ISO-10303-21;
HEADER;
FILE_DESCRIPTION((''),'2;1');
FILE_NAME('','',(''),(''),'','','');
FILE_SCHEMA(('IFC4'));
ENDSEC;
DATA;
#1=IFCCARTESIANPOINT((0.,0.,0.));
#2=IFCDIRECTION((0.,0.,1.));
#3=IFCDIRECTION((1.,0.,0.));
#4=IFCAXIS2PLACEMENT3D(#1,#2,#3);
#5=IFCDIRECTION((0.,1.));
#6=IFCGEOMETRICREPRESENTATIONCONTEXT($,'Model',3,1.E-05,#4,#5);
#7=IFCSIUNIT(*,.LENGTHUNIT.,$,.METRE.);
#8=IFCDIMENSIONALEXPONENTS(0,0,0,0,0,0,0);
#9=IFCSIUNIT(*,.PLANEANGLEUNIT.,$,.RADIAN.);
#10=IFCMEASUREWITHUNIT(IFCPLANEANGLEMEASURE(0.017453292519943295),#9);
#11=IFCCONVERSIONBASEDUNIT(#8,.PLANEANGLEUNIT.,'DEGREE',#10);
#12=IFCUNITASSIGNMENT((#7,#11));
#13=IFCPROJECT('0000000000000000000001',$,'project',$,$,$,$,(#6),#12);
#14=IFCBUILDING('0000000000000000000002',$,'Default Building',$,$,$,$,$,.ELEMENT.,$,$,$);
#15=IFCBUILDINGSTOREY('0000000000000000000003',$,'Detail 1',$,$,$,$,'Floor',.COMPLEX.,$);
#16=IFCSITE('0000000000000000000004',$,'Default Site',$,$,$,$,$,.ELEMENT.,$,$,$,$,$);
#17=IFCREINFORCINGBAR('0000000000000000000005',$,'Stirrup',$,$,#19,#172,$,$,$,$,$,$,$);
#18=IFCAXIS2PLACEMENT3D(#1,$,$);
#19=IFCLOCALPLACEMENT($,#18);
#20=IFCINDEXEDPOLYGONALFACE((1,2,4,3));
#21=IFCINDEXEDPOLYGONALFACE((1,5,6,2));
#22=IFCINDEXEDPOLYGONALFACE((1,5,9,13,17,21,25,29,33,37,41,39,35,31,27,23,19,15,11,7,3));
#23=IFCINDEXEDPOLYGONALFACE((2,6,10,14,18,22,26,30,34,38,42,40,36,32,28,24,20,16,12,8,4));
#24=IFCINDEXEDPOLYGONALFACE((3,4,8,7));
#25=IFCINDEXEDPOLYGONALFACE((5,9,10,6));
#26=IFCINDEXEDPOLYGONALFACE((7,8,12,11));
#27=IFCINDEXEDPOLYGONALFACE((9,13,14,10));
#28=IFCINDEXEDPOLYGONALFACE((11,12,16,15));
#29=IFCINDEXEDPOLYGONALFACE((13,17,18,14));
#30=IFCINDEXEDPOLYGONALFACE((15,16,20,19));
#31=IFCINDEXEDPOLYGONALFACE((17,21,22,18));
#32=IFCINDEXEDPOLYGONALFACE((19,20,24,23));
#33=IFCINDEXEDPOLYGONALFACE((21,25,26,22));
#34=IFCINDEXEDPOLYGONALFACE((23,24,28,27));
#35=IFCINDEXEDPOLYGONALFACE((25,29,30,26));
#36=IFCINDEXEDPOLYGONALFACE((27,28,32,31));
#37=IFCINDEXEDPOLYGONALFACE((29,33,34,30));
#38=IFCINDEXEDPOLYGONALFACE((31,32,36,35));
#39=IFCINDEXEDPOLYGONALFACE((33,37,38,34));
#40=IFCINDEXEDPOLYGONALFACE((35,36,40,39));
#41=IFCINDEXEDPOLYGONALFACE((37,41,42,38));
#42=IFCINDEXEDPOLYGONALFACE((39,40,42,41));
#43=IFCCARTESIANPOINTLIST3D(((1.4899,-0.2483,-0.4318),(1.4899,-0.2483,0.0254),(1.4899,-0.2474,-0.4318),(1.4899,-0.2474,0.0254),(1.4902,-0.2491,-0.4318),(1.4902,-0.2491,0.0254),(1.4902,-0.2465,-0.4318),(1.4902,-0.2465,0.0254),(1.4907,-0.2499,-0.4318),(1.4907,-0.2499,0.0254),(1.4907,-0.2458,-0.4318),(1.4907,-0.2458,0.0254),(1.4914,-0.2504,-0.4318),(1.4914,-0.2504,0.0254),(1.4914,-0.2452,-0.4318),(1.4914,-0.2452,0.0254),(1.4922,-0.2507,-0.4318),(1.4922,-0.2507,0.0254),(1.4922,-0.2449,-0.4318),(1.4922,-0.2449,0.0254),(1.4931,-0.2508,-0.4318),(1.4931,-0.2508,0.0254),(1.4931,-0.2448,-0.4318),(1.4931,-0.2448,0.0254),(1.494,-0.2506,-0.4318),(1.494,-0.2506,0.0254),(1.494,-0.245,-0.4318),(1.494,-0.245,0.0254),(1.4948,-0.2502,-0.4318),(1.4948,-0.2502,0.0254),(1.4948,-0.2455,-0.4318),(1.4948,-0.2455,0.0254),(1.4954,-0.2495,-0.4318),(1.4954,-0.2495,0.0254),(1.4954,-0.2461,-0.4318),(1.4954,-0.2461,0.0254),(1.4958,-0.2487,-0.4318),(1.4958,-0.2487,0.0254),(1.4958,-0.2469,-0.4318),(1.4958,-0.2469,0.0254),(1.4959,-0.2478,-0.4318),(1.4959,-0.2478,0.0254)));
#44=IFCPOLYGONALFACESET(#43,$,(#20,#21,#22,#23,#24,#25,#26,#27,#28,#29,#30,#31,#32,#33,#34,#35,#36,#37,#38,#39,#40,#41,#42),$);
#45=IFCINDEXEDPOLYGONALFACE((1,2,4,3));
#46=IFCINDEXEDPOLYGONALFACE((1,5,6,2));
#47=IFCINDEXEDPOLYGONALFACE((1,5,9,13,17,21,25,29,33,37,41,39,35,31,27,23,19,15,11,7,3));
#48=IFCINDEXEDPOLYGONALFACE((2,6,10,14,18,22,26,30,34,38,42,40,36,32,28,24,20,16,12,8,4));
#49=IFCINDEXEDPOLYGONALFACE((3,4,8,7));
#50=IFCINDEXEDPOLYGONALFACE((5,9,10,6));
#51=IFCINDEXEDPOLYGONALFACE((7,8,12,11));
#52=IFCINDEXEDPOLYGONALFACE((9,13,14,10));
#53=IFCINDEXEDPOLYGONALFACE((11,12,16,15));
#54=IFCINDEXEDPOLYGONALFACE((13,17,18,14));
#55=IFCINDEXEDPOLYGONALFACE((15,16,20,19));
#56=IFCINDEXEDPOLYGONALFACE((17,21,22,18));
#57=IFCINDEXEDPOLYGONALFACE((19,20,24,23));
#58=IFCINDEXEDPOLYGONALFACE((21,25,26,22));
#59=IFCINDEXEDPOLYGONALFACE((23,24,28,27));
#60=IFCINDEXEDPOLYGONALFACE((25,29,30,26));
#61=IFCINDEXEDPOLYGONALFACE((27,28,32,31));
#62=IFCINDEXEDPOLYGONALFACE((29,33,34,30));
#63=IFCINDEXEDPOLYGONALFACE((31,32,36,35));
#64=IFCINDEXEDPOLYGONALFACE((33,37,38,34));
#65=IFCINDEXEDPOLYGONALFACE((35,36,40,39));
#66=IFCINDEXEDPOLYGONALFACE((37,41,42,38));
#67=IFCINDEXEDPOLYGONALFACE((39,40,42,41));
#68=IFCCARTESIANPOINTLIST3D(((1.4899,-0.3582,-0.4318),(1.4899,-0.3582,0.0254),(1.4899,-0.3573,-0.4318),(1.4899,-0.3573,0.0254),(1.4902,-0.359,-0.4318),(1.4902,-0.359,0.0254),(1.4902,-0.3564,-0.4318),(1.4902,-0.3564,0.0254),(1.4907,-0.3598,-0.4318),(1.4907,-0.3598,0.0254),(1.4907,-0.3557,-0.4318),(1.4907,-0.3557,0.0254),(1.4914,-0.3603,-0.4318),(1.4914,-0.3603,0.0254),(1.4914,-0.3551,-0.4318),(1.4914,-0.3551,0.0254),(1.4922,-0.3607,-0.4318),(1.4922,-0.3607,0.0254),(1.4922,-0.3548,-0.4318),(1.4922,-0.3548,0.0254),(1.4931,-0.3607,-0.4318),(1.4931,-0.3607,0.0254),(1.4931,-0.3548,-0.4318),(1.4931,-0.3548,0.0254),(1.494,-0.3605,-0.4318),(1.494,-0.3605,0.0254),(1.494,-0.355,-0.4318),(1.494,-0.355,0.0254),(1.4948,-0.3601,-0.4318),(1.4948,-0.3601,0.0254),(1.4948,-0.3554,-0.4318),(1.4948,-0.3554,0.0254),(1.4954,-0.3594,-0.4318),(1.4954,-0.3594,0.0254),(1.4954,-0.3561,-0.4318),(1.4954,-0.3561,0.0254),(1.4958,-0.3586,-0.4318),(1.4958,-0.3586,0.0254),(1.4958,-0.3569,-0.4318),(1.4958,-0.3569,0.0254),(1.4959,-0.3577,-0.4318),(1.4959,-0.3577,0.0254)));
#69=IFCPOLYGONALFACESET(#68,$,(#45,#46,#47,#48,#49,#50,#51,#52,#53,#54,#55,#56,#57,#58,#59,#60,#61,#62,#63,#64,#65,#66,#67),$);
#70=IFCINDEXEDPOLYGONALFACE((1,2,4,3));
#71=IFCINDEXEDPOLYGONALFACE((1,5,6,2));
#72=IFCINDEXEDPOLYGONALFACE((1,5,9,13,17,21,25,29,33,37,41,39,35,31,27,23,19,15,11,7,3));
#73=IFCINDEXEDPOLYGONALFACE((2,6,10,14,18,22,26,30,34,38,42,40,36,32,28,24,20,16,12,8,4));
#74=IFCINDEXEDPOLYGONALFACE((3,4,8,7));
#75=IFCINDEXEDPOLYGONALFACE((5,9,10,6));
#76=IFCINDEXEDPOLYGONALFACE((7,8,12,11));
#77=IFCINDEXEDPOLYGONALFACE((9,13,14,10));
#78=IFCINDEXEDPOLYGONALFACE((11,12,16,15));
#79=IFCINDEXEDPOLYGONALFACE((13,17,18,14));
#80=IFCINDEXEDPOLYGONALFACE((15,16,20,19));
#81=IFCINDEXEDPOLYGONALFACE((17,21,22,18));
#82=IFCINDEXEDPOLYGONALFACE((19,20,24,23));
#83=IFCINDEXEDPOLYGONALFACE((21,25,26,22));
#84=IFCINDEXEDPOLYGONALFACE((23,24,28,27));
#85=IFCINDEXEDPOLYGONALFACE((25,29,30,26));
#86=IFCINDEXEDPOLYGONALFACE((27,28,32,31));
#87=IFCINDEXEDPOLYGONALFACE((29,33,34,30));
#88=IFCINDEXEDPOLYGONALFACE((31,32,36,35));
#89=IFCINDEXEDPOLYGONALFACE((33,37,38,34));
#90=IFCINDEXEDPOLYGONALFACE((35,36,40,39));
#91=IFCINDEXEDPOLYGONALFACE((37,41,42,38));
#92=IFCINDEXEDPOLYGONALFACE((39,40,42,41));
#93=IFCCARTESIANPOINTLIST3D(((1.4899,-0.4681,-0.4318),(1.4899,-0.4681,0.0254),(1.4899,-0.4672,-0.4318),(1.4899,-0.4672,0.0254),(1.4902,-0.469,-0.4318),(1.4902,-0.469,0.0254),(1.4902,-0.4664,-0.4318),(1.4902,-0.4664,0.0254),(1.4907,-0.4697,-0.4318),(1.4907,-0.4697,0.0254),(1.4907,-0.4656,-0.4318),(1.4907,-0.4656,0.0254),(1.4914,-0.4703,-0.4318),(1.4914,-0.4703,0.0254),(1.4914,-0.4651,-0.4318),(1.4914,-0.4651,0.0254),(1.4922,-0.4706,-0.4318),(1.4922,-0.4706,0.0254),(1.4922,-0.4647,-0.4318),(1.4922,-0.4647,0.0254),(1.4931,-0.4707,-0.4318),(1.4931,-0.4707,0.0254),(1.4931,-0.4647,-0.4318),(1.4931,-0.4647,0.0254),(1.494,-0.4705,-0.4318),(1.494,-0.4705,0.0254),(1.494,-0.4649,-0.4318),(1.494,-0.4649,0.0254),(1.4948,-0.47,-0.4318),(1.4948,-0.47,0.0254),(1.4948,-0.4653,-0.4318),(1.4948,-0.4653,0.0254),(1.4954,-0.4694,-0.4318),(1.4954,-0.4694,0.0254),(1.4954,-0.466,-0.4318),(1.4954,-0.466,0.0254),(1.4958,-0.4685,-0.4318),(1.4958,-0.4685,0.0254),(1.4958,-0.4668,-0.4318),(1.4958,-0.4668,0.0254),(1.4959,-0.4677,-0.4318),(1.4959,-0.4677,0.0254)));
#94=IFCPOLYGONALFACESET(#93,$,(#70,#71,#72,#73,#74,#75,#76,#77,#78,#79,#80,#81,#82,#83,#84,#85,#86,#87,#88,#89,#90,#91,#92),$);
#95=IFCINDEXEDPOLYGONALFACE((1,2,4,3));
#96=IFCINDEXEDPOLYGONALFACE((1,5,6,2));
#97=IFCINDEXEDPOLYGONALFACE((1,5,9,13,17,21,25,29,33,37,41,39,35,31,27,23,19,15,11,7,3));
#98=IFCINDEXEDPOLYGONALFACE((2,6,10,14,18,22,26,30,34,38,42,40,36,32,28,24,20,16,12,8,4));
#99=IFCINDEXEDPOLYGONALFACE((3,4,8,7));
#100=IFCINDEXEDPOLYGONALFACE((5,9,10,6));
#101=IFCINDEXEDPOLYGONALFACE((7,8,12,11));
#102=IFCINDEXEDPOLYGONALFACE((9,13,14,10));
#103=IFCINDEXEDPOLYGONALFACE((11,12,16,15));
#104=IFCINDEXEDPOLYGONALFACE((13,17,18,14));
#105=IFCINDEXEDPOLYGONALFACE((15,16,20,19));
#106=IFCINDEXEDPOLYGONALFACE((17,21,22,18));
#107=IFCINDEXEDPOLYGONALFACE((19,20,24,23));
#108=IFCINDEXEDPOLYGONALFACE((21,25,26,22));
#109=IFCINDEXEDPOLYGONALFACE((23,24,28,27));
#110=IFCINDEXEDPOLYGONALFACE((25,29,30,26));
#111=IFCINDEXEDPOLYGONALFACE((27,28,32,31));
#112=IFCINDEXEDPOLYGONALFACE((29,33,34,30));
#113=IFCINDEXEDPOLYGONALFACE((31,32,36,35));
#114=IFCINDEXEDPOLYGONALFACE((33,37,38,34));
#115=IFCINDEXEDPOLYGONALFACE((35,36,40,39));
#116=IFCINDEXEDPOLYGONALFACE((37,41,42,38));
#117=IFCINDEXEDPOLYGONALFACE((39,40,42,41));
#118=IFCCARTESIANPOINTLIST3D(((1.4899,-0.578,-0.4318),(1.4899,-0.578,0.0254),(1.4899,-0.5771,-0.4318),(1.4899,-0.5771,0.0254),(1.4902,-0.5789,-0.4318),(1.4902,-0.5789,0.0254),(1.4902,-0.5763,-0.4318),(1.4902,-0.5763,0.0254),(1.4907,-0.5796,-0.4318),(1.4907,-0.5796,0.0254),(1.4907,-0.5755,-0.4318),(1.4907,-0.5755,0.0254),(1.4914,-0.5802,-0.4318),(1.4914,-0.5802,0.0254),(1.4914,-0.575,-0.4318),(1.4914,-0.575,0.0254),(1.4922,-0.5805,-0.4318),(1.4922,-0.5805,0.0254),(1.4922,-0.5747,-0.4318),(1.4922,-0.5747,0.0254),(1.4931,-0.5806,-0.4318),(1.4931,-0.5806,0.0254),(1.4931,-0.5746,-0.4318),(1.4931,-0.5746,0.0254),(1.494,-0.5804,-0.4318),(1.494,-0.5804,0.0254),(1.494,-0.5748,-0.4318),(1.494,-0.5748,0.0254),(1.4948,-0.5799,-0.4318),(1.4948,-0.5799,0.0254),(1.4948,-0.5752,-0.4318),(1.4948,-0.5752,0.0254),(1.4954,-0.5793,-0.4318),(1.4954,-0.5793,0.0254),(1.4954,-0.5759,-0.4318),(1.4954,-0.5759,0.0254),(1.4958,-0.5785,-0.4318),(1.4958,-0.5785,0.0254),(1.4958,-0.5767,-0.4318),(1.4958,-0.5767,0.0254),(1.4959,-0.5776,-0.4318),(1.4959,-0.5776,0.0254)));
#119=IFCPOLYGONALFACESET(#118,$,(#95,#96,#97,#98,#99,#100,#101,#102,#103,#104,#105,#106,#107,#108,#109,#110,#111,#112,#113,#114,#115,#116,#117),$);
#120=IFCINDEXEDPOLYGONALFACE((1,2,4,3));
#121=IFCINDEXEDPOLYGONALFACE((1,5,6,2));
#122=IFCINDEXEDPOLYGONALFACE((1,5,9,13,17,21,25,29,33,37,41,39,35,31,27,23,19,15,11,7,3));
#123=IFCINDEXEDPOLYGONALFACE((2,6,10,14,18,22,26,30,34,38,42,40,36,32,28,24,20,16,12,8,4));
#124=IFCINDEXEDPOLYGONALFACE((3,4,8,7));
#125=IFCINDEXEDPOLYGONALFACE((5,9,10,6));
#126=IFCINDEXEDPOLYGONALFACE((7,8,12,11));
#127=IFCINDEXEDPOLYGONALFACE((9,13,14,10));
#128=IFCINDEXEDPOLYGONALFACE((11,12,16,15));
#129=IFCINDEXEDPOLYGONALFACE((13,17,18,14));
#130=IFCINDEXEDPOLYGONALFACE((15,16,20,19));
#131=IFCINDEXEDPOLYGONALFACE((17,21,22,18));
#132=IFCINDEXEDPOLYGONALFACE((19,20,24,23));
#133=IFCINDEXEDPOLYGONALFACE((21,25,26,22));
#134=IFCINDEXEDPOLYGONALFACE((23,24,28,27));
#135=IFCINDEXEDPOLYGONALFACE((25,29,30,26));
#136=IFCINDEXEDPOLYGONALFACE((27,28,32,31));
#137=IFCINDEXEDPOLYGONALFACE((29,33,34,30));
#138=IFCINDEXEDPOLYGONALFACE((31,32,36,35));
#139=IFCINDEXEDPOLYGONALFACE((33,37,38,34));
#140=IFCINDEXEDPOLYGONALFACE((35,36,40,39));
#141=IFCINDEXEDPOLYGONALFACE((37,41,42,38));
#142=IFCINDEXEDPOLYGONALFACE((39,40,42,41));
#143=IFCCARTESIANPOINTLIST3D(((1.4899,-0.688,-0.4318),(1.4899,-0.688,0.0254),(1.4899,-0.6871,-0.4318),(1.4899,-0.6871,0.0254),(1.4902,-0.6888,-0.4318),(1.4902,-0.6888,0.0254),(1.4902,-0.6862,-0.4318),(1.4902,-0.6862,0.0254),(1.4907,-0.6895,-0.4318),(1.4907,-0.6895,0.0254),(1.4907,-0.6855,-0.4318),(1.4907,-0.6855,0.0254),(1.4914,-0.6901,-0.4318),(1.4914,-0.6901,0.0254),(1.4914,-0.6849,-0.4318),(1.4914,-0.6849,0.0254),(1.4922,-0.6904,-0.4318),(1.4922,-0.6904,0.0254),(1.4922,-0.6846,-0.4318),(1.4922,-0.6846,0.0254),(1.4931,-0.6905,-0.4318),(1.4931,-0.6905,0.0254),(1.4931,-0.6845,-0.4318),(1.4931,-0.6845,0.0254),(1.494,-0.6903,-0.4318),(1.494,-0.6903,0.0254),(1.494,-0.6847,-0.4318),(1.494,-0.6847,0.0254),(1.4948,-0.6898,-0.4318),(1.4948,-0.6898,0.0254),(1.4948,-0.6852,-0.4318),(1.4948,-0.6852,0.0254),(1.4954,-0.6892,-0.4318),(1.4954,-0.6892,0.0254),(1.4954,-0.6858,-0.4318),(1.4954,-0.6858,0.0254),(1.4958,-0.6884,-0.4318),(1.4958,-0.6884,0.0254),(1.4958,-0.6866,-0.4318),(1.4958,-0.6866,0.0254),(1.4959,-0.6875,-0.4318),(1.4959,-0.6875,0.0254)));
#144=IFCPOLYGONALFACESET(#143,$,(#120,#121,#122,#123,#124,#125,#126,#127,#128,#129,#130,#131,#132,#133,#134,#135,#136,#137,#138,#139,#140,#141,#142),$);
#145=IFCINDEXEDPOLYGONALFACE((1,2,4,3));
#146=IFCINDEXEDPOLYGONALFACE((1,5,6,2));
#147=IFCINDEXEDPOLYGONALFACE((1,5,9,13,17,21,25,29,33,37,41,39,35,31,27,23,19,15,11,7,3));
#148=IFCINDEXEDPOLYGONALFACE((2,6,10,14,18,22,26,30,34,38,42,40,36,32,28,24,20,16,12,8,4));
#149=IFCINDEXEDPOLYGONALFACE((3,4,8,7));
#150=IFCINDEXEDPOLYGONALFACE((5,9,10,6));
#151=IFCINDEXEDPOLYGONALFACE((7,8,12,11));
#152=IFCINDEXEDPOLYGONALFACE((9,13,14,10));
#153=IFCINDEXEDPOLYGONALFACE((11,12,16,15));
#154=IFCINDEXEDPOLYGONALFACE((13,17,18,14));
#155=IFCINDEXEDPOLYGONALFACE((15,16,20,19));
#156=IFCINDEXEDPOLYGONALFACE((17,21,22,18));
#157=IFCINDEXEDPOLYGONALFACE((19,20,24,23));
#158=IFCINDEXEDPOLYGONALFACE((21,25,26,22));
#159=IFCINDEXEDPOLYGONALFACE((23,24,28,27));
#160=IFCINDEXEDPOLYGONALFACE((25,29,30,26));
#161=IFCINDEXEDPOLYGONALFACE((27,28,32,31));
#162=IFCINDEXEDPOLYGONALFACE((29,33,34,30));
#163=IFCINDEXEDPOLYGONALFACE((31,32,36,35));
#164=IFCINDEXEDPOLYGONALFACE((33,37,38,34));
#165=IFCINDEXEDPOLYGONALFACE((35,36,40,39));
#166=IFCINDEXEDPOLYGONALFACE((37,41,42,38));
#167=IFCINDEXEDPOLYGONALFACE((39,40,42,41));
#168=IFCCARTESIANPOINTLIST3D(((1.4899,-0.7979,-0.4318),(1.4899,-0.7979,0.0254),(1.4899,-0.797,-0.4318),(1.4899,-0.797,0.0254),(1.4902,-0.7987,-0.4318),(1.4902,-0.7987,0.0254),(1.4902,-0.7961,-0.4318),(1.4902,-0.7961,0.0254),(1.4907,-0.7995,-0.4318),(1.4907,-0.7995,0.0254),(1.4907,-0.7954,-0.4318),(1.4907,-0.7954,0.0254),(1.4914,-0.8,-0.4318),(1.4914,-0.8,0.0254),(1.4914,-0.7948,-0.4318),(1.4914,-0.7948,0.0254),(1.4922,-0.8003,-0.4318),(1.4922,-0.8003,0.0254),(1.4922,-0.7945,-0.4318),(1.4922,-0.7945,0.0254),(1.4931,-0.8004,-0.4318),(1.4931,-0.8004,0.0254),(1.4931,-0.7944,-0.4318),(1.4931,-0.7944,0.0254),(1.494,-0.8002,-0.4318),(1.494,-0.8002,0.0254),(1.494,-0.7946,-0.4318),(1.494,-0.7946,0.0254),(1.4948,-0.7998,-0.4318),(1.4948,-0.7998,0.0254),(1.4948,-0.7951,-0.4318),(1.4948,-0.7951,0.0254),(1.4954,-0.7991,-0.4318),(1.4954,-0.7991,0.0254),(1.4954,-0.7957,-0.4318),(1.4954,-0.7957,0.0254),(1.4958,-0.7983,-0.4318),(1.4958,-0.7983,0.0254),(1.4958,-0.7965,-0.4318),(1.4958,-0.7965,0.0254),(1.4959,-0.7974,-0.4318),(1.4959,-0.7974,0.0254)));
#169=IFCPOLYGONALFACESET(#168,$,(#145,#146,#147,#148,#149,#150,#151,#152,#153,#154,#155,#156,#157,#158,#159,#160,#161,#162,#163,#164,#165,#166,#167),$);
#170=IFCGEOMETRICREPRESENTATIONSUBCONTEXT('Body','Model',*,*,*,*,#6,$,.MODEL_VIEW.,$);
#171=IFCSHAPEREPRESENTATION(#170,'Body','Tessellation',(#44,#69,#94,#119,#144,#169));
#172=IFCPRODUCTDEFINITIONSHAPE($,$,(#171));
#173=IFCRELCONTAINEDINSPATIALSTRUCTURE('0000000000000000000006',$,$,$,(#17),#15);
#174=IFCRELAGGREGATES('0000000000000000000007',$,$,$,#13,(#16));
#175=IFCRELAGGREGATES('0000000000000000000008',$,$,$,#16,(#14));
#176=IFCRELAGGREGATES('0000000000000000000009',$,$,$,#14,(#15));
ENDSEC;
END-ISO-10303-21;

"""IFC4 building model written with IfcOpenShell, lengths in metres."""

from ifc_helpers import new_model, entity, si_unit, converted_unit, direction, origin_with_axes, place, context, subcontext, project, spatial, element, save


model = new_model("IFC4")

# Units and contexts
model_context = context("Model", 3, precision=1e-05, world=origin_with_axes(), true_north=direction((0.0, 1.0)))
body_context = subcontext(model_context, "Body", "Model", "MODEL_VIEW")
ifc_project = project(units=[si_unit("LENGTHUNIT", "METRE"), converted_unit("PLANEANGLEUNIT", "DEGREE", entity("IfcPlaneAngleMeasure", 0.017453292519943295), si_unit("PLANEANGLEUNIT", "RADIAN"), dimensions=[0, 0, 0, 0, 0, 0, 0])], contexts=[model_context])

# Site, building, storey
site = spatial("IfcSite", under=ifc_project, Name="Default Site", CompositionType="ELEMENT")
building = spatial("IfcBuilding", under=site, Name="Default Building", CompositionType="ELEMENT")
storey = spatial("IfcBuildingStorey", under=building, Name="Detail 1", LongName="Floor", CompositionType="COMPLEX")

# Shared definitions
placement = place(None, origin_with_axes())

# Reinforcing bar
element("IfcReinforcingBar", 1, at=placement, inside=storey, Name="Stirrup", context=body_context, shape_type="SweptSolid", body=[
    entity("IfcSweptDiskSolid", entity("IfcCompositeCurve", [entity("IfcCompositeCurveSegment", "CONTINUOUS", True, entity("IfcPolyline", [entity("IfcCartesianPoint", [1.4929, -0.2478, -0.4318]), entity("IfcCartesianPoint", [1.4929, -0.2478, 0.0254])]))], False), 0.003),
    entity("IfcSweptDiskSolid", entity("IfcCompositeCurve", [entity("IfcCompositeCurveSegment", "CONTINUOUS", True, entity("IfcPolyline", [entity("IfcCartesianPoint", [1.4929, -0.3577, -0.4318]), entity("IfcCartesianPoint", [1.4929, -0.3577, 0.0254])]))], False), 0.003),
    entity("IfcSweptDiskSolid", entity("IfcCompositeCurve", [entity("IfcCompositeCurveSegment", "CONTINUOUS", True, entity("IfcPolyline", [entity("IfcCartesianPoint", [1.4929, -0.4677, -0.4318]), entity("IfcCartesianPoint", [1.4929, -0.4677, 0.0254])]))], False), 0.003),
    entity("IfcSweptDiskSolid", entity("IfcCompositeCurve", [entity("IfcCompositeCurveSegment", "CONTINUOUS", True, entity("IfcPolyline", [entity("IfcCartesianPoint", [1.4929, -0.5776, -0.4318]), entity("IfcCartesianPoint", [1.4929, -0.5776, 0.0254])]))], False), 0.003),
    entity("IfcSweptDiskSolid", entity("IfcCompositeCurve", [entity("IfcCompositeCurveSegment", "CONTINUOUS", True, entity("IfcPolyline", [entity("IfcCartesianPoint", [1.4929, -0.6875, -0.4318]), entity("IfcCartesianPoint", [1.4929, -0.6875, 0.0254])]))], False), 0.003),
    entity("IfcSweptDiskSolid", entity("IfcCompositeCurve", [entity("IfcCompositeCurveSegment", "CONTINUOUS", True, entity("IfcPolyline", [entity("IfcCartesianPoint", [1.4929, -0.7974, -0.4318]), entity("IfcCartesianPoint", [1.4929, -0.7974, 0.0254])]))], False), 0.003),
])

save(model, "model.ifc")
